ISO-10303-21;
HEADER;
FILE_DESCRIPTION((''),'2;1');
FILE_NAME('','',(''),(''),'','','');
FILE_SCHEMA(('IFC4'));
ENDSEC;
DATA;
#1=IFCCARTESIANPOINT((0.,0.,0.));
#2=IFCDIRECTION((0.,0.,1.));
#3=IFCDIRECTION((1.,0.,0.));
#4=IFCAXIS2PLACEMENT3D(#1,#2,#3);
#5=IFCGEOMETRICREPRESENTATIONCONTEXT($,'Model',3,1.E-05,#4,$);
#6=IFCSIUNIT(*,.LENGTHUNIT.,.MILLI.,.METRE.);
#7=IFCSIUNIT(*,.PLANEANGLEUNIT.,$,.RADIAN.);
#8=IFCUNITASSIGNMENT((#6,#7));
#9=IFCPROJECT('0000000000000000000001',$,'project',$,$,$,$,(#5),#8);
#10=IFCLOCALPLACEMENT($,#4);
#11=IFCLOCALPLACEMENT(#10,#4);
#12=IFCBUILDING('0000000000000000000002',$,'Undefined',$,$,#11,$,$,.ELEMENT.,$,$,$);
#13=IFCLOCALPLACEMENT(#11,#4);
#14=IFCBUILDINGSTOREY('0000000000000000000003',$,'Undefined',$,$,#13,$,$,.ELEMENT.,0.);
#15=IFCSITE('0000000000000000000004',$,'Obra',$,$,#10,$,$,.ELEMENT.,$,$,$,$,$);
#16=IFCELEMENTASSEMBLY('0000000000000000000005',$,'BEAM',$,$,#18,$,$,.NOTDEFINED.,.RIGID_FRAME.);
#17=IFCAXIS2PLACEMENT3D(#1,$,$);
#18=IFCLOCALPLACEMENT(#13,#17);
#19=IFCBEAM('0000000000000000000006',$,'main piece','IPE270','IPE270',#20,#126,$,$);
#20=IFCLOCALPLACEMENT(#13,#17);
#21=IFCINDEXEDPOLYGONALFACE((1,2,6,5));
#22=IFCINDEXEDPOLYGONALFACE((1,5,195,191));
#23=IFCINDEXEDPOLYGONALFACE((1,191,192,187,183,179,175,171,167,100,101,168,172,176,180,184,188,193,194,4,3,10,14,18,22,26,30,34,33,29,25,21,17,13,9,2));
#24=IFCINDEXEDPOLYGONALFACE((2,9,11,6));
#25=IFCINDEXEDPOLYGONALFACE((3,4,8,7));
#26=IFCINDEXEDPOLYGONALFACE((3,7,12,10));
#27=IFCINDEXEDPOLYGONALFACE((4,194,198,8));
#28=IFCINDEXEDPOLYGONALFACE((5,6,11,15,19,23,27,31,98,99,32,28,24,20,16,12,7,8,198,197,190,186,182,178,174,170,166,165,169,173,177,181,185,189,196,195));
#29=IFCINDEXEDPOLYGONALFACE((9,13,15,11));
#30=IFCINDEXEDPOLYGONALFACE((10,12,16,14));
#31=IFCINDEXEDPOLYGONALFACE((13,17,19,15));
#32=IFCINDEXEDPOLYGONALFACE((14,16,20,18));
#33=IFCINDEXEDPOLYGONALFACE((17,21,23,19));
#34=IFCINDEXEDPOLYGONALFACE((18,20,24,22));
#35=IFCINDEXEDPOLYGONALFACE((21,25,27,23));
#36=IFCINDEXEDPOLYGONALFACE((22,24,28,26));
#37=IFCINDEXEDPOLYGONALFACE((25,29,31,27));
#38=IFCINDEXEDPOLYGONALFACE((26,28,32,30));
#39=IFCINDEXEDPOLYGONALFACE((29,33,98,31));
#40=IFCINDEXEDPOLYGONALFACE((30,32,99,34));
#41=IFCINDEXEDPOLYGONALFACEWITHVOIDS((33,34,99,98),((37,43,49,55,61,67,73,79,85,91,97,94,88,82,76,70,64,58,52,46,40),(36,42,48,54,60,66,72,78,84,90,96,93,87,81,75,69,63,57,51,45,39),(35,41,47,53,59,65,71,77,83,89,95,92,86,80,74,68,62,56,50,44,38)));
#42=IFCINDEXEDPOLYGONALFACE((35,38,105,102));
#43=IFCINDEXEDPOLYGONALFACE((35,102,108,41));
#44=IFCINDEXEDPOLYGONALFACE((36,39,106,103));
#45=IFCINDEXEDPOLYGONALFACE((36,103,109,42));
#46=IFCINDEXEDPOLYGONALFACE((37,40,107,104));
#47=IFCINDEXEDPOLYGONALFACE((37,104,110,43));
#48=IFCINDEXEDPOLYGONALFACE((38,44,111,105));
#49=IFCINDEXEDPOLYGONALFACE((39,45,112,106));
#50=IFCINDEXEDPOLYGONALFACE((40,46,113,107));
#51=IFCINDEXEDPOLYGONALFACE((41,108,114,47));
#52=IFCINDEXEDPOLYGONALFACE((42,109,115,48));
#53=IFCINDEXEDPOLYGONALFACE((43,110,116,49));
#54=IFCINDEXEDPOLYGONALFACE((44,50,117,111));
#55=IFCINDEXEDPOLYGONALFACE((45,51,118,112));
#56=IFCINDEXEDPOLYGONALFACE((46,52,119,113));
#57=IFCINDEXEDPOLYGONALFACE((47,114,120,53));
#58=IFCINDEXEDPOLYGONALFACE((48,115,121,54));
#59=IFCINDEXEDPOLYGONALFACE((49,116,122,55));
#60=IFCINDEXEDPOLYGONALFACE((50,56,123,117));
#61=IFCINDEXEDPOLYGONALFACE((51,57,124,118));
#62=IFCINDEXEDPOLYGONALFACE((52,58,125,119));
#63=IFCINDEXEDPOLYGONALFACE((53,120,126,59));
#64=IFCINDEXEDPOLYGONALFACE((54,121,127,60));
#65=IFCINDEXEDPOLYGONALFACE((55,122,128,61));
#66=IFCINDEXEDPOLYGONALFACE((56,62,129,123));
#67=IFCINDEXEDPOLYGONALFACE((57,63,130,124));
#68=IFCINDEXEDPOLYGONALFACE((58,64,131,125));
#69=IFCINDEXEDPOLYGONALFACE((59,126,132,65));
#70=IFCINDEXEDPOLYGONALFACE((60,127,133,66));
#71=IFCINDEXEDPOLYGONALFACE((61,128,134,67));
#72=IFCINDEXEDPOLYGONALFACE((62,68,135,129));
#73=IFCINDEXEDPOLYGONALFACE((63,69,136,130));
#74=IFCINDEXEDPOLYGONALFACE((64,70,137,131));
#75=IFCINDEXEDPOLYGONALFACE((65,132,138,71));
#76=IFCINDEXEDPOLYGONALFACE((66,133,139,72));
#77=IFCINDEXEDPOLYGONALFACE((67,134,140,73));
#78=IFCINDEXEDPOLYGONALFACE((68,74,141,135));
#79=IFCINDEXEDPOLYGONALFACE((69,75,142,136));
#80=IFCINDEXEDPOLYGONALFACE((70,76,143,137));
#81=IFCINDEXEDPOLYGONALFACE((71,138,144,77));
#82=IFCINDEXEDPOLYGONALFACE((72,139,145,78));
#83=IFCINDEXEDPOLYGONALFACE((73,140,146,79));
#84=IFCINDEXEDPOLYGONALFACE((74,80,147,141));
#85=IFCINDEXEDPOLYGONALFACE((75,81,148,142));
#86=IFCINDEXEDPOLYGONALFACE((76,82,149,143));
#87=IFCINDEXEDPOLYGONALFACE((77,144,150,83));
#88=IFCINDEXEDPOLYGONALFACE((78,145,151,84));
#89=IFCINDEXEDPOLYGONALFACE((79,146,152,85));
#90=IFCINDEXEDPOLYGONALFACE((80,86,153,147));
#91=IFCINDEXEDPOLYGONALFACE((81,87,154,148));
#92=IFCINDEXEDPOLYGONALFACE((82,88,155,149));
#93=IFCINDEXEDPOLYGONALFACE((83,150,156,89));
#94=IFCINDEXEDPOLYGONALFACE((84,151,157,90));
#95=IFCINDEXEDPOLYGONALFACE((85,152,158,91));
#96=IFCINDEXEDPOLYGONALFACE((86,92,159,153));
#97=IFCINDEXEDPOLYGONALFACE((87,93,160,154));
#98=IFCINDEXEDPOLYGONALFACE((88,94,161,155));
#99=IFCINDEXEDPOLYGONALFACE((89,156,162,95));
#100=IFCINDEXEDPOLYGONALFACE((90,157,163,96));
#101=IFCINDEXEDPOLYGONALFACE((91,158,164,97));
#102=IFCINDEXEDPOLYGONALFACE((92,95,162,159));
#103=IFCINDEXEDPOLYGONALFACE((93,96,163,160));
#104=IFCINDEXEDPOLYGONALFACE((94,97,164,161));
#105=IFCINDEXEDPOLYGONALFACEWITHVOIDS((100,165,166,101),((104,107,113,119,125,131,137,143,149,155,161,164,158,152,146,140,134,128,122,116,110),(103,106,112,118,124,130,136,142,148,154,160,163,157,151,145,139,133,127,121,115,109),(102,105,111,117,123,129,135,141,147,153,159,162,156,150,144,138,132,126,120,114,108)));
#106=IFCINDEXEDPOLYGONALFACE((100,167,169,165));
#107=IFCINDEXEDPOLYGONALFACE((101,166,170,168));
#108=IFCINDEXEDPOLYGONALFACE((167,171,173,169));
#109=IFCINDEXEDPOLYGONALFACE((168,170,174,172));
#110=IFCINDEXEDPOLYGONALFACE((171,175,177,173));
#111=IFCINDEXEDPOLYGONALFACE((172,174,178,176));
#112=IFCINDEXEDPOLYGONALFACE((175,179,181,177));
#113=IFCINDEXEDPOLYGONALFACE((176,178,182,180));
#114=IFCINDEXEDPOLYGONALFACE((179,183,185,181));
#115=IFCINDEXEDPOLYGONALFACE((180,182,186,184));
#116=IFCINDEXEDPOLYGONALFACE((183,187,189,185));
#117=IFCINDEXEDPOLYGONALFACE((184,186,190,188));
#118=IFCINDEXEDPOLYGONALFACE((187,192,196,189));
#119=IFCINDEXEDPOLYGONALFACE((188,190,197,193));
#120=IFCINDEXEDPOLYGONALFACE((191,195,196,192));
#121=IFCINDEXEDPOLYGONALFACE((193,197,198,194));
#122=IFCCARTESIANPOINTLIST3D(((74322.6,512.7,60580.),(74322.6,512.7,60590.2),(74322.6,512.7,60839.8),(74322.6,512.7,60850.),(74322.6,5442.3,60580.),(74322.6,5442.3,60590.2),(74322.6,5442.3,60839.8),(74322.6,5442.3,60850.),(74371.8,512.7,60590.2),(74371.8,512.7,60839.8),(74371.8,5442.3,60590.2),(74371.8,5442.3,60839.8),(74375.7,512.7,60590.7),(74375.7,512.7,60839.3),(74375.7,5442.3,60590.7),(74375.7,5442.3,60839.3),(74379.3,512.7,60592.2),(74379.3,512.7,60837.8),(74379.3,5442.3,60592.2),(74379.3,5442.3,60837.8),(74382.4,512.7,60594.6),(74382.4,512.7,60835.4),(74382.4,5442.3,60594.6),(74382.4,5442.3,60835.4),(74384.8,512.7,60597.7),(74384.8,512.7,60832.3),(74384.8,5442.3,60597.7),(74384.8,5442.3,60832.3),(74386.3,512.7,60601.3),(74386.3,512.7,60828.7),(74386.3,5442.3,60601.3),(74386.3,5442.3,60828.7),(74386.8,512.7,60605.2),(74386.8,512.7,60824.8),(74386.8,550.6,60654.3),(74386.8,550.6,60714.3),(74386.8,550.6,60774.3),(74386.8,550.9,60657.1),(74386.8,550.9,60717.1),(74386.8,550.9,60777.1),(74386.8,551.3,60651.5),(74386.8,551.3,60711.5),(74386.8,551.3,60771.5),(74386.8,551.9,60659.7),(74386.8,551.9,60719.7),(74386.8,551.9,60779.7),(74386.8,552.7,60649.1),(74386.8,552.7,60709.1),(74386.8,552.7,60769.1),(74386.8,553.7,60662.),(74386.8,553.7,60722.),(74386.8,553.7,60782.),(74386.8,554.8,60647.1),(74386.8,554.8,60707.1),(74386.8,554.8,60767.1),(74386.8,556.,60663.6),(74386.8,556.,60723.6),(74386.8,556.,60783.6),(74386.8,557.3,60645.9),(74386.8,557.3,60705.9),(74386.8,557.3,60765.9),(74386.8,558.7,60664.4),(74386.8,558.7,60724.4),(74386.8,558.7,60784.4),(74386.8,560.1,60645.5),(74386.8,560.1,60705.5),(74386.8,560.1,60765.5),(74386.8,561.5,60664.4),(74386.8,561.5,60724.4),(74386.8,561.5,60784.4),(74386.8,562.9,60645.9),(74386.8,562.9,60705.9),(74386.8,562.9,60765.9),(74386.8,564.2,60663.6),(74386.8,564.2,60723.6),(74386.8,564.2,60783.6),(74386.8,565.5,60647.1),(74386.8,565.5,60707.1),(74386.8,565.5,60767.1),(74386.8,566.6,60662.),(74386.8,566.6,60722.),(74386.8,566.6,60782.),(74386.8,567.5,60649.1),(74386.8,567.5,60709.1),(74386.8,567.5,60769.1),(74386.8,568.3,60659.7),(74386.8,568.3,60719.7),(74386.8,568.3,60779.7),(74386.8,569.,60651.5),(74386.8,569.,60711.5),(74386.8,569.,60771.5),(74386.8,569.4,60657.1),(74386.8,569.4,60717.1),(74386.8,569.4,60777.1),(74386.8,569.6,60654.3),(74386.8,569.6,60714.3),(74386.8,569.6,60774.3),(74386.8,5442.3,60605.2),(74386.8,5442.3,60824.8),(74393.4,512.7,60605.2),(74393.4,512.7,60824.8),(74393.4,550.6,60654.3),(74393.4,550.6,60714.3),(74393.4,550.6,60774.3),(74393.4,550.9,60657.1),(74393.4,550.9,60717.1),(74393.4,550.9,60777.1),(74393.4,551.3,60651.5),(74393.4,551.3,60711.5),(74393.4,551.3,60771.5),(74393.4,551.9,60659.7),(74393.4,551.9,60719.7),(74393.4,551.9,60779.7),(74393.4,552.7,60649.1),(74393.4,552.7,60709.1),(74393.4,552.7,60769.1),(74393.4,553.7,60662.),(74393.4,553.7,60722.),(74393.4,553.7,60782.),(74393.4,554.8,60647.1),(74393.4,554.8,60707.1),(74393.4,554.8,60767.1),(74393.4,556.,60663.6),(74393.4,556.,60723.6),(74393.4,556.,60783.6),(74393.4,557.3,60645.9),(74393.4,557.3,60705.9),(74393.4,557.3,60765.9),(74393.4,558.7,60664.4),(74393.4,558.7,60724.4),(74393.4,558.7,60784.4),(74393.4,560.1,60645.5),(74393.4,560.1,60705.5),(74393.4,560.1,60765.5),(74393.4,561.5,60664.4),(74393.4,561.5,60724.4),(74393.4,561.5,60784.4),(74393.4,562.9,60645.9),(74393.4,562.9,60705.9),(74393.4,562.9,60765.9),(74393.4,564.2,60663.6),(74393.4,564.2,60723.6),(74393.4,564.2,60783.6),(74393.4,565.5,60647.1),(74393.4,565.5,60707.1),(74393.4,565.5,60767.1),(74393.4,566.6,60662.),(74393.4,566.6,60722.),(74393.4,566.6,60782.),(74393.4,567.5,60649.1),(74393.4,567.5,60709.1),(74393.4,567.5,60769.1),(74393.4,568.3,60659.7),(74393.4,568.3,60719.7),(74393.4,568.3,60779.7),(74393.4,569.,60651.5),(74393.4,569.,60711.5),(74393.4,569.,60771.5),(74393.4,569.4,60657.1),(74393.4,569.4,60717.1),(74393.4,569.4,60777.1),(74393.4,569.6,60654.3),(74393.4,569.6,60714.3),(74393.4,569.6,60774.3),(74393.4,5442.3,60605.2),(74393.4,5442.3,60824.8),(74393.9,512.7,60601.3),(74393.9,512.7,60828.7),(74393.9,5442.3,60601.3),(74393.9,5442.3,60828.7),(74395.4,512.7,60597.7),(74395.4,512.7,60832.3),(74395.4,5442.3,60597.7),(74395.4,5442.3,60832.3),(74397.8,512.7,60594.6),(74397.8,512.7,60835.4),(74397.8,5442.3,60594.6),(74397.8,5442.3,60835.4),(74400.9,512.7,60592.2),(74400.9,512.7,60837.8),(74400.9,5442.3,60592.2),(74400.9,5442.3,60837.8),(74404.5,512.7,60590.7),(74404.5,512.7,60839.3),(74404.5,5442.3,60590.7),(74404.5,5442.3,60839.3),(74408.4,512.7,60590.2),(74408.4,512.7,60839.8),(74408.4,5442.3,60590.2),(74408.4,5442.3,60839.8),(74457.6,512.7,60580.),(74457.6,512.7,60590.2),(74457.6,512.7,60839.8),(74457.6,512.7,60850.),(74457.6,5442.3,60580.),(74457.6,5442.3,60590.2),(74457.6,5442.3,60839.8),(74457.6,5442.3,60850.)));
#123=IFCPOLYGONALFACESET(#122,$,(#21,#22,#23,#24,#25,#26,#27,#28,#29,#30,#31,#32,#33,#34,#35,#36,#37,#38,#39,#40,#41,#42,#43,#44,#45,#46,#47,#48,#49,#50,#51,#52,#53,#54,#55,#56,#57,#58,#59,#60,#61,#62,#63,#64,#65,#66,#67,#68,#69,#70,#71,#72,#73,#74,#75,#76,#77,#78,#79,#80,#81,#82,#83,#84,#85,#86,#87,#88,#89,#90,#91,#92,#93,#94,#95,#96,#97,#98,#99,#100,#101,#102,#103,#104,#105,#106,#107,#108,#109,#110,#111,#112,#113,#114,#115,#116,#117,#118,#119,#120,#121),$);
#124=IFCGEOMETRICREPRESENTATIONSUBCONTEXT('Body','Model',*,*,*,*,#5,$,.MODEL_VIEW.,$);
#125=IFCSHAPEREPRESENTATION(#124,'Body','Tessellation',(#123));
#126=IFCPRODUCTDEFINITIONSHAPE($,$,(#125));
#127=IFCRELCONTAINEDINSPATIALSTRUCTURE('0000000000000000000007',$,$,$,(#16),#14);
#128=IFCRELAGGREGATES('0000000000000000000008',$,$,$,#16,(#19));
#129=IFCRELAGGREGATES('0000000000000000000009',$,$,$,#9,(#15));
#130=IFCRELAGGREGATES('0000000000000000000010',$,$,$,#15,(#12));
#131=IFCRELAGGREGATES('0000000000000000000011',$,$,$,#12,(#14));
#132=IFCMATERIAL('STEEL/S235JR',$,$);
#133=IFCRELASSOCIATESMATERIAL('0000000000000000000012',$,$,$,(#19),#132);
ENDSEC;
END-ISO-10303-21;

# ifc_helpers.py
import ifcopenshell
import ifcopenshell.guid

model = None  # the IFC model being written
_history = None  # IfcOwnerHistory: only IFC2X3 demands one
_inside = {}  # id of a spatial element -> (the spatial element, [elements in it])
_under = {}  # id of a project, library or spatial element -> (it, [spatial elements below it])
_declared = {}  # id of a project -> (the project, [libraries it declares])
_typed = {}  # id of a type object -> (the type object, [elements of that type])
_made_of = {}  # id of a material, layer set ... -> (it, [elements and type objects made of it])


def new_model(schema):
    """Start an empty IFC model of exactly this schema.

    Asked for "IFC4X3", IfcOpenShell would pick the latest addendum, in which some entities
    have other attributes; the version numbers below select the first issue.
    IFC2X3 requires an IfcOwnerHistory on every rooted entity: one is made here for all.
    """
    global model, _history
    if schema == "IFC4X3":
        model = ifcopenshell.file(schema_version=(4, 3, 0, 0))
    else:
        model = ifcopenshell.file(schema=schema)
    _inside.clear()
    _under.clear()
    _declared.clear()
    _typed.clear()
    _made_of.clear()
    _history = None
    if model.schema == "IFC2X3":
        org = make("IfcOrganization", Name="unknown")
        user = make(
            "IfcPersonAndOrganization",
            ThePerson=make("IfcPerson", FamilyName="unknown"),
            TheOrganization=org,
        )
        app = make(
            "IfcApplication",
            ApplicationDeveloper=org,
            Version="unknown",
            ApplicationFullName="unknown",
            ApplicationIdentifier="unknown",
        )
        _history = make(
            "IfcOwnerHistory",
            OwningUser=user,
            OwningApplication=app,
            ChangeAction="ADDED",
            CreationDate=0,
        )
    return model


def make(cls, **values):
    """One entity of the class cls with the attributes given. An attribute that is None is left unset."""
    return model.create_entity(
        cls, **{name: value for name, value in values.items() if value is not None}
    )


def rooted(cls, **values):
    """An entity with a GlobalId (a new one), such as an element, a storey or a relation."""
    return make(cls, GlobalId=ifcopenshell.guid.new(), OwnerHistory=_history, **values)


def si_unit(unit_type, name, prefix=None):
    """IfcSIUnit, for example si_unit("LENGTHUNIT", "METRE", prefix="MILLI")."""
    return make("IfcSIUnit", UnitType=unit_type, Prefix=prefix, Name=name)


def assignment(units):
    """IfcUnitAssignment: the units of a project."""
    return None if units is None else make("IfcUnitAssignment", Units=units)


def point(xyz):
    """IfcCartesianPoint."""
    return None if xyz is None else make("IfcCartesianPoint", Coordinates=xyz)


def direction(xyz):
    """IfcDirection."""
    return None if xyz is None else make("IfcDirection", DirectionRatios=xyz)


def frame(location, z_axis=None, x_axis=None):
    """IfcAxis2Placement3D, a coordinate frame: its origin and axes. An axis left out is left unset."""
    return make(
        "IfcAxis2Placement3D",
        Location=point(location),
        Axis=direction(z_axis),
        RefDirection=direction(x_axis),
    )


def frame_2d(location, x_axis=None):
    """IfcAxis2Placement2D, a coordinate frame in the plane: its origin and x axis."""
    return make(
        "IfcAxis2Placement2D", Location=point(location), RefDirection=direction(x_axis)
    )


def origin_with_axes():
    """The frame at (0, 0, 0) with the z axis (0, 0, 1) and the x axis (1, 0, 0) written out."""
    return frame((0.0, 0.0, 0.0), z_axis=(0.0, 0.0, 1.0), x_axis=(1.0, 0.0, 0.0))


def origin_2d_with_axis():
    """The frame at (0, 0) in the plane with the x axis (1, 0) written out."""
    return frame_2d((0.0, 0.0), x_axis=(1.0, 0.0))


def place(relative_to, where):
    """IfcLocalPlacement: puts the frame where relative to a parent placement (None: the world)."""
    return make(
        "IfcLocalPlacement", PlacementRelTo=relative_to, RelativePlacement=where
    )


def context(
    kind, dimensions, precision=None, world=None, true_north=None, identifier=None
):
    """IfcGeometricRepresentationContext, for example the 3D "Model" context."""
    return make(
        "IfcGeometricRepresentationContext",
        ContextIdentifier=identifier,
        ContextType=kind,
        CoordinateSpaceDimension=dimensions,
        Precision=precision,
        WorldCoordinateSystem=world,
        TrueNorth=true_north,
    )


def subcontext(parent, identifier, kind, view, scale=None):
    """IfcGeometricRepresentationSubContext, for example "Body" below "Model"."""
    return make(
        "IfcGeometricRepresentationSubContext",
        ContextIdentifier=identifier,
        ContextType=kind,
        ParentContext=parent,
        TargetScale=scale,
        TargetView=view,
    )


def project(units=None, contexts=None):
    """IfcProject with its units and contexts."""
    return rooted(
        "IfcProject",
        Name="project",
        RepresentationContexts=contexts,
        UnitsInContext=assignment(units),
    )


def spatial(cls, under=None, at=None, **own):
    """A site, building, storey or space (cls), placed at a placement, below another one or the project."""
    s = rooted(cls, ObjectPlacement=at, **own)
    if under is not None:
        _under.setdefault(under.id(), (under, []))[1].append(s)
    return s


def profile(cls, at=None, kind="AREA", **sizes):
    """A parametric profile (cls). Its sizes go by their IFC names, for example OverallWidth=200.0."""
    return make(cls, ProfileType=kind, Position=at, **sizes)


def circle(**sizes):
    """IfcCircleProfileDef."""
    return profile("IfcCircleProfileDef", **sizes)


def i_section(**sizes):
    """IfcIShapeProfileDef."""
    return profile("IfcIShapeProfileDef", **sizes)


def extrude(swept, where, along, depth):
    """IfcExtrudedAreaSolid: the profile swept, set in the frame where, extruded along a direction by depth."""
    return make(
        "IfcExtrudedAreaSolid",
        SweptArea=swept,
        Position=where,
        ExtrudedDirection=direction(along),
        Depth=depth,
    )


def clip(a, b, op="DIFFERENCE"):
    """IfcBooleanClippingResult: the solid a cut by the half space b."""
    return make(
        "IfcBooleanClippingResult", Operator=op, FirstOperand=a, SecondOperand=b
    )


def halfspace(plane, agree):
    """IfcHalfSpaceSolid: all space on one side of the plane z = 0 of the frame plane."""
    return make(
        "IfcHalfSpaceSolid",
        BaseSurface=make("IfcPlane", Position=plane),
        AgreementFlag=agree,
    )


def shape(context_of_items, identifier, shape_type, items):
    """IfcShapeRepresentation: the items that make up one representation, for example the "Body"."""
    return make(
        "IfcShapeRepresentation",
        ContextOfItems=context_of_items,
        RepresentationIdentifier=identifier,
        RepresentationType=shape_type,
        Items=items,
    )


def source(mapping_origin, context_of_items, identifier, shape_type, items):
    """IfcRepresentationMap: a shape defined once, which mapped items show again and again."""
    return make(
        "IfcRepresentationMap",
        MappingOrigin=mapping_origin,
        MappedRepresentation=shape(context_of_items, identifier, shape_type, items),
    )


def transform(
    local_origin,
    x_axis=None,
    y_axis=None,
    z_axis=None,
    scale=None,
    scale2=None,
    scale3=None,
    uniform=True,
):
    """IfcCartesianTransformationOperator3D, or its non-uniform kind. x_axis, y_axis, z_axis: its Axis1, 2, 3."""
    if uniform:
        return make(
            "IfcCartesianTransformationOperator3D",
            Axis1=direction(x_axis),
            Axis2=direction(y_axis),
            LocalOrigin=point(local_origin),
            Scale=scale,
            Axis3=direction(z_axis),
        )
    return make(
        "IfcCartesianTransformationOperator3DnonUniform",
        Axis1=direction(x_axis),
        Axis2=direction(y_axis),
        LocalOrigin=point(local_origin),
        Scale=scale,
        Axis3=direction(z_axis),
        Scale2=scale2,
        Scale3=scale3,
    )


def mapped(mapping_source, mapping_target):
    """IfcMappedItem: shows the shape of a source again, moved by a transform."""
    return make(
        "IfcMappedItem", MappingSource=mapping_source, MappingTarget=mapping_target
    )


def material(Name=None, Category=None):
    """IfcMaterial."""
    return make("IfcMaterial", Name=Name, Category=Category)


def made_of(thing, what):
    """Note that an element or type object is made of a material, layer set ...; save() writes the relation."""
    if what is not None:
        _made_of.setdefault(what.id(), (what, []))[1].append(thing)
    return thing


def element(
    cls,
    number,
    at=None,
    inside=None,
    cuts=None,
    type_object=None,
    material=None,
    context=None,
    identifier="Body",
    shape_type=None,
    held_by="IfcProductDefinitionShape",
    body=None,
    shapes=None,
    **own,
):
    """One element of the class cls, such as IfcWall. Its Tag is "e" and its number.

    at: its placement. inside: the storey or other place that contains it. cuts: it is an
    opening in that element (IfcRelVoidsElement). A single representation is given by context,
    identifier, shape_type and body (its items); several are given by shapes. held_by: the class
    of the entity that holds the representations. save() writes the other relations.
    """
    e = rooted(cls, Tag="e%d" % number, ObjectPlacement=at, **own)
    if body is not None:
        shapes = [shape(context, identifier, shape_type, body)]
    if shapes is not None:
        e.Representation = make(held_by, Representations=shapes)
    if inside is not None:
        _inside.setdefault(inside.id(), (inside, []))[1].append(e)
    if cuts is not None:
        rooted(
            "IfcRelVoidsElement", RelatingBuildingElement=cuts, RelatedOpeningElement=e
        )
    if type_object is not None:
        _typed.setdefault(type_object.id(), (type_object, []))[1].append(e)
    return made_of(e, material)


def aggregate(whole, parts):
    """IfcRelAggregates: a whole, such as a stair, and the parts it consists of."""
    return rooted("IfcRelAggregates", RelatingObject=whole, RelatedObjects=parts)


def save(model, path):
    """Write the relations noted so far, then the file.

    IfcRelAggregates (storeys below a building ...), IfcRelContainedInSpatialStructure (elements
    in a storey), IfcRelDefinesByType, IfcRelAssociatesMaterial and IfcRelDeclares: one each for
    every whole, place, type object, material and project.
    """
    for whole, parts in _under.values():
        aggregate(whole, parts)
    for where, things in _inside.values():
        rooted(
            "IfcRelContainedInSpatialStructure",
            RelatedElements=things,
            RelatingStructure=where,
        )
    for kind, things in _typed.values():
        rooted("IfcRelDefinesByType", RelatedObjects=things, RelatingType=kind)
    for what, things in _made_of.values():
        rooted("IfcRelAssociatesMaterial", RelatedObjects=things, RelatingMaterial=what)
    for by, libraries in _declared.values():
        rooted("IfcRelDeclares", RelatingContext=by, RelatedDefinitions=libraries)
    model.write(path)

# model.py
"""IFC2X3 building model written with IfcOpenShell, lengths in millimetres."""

from ifc_helpers import new_model, si_unit, frame, origin_with_axes, origin_2d_with_axis, place, context, subcontext, project, spatial, circle, i_section, extrude, clip, halfspace, source, transform, mapped, material, element, aggregate, save


model = new_model("IFC2X3")

# Units and contexts
model_context = context("Model", 3, precision=1e-05, world=origin_with_axes())
body_context = subcontext(model_context, "Body", "Model", "MODEL_VIEW")
ifc_project = project(units=[si_unit("LENGTHUNIT", "METRE", prefix="MILLI"), si_unit("PLANEANGLEUNIT", "RADIAN")], contexts=[model_context])

# Site, building, storey
site_placement = place(None, origin_with_axes())
site = spatial("IfcSite", under=ifc_project, at=site_placement, Name="Obra", CompositionType="ELEMENT")
building_placement = place(site_placement, origin_with_axes())
building = spatial("IfcBuilding", under=site, at=building_placement, Name="Undefined", CompositionType="ELEMENT")
storey_placement = place(building_placement, origin_with_axes())
storey = spatial("IfcBuildingStorey", under=building, at=storey_placement, Name="Undefined", CompositionType="ELEMENT", Elevation=0.0)

# Shared definitions
ifc_material_1 = material(Name="STEEL/S235JR")

# Shared definitions
shared_shape_1 = source(origin_with_axes(), body_context, "Body", "SweptSolid", [
    extrude(circle(Radius=9.5, at=origin_2d_with_axis()), frame((0.0, -3.4, 0.0), z_axis=(0.0, 1.0, 0.0), x_axis=(1.0, 0.0, 0.0)), (0.0, 0.0, 1.0), 6.8),
])

# Element assembly, beam, opening
assembly_1_placement = place(storey_placement, origin_with_axes())
assembly_1 = element("IfcElementAssembly", 1, at=assembly_1_placement, inside=storey, Name="BEAM", AssemblyPlace="NOTDEFINED", PredefinedType="RIGID_FRAME")
beam_1_placement = place(assembly_1_placement, frame((74390.1, 512.7, 60715.0), z_axis=(0.0, 0.0, 1.0), x_axis=(0.0, 1.0, 0.0)))
beam_1 = element("IfcBeam", 2, at=beam_1_placement, material=ifc_material_1, Name="main piece", Description="IPE270", ObjectType="IPE270", context=body_context, shape_type="Clipping", body=[
    clip(extrude(i_section(OverallWidth=135.0, OverallDepth=270.0, WebThickness=6.6, FlangeThickness=10.2, FilletRadius=15.0, at=origin_2d_with_axis()), frame((4929.6, 0.0, 0.0), z_axis=(-1.0, 0.0, 0.0), x_axis=(0.0, -1.0, 0.0)), (0.0, 0.0, 1.0), 4929.6), halfspace(frame((-2.2, 60.0, -120.0), z_axis=(-1.0, -0.000021, 0.0), x_axis=(0.0, 0.0, 1.0)), False)),
])
opening_1_placement = place(assembly_1_placement, frame((74390.1, 510.1, 60835.0), z_axis=(-0.000002, 1.0, 0.0), x_axis=(0.0, 0.0, -1.0)))
element("IfcOpeningElement", 3, at=opening_1_placement, cuts=beam_1, ObjectType="Opening", context=body_context, shape_type="MappedRepresentation", body=[
    mapped(shared_shape_1, transform((60.0, 0.0, 50.0))),
    mapped(shared_shape_1, transform((120.0, 0.0, 50.0))),
    mapped(shared_shape_1, transform((180.0, 0.0, 50.0))),
])
aggregate(assembly_1, [beam_1])

save(model, "model.ifc")
